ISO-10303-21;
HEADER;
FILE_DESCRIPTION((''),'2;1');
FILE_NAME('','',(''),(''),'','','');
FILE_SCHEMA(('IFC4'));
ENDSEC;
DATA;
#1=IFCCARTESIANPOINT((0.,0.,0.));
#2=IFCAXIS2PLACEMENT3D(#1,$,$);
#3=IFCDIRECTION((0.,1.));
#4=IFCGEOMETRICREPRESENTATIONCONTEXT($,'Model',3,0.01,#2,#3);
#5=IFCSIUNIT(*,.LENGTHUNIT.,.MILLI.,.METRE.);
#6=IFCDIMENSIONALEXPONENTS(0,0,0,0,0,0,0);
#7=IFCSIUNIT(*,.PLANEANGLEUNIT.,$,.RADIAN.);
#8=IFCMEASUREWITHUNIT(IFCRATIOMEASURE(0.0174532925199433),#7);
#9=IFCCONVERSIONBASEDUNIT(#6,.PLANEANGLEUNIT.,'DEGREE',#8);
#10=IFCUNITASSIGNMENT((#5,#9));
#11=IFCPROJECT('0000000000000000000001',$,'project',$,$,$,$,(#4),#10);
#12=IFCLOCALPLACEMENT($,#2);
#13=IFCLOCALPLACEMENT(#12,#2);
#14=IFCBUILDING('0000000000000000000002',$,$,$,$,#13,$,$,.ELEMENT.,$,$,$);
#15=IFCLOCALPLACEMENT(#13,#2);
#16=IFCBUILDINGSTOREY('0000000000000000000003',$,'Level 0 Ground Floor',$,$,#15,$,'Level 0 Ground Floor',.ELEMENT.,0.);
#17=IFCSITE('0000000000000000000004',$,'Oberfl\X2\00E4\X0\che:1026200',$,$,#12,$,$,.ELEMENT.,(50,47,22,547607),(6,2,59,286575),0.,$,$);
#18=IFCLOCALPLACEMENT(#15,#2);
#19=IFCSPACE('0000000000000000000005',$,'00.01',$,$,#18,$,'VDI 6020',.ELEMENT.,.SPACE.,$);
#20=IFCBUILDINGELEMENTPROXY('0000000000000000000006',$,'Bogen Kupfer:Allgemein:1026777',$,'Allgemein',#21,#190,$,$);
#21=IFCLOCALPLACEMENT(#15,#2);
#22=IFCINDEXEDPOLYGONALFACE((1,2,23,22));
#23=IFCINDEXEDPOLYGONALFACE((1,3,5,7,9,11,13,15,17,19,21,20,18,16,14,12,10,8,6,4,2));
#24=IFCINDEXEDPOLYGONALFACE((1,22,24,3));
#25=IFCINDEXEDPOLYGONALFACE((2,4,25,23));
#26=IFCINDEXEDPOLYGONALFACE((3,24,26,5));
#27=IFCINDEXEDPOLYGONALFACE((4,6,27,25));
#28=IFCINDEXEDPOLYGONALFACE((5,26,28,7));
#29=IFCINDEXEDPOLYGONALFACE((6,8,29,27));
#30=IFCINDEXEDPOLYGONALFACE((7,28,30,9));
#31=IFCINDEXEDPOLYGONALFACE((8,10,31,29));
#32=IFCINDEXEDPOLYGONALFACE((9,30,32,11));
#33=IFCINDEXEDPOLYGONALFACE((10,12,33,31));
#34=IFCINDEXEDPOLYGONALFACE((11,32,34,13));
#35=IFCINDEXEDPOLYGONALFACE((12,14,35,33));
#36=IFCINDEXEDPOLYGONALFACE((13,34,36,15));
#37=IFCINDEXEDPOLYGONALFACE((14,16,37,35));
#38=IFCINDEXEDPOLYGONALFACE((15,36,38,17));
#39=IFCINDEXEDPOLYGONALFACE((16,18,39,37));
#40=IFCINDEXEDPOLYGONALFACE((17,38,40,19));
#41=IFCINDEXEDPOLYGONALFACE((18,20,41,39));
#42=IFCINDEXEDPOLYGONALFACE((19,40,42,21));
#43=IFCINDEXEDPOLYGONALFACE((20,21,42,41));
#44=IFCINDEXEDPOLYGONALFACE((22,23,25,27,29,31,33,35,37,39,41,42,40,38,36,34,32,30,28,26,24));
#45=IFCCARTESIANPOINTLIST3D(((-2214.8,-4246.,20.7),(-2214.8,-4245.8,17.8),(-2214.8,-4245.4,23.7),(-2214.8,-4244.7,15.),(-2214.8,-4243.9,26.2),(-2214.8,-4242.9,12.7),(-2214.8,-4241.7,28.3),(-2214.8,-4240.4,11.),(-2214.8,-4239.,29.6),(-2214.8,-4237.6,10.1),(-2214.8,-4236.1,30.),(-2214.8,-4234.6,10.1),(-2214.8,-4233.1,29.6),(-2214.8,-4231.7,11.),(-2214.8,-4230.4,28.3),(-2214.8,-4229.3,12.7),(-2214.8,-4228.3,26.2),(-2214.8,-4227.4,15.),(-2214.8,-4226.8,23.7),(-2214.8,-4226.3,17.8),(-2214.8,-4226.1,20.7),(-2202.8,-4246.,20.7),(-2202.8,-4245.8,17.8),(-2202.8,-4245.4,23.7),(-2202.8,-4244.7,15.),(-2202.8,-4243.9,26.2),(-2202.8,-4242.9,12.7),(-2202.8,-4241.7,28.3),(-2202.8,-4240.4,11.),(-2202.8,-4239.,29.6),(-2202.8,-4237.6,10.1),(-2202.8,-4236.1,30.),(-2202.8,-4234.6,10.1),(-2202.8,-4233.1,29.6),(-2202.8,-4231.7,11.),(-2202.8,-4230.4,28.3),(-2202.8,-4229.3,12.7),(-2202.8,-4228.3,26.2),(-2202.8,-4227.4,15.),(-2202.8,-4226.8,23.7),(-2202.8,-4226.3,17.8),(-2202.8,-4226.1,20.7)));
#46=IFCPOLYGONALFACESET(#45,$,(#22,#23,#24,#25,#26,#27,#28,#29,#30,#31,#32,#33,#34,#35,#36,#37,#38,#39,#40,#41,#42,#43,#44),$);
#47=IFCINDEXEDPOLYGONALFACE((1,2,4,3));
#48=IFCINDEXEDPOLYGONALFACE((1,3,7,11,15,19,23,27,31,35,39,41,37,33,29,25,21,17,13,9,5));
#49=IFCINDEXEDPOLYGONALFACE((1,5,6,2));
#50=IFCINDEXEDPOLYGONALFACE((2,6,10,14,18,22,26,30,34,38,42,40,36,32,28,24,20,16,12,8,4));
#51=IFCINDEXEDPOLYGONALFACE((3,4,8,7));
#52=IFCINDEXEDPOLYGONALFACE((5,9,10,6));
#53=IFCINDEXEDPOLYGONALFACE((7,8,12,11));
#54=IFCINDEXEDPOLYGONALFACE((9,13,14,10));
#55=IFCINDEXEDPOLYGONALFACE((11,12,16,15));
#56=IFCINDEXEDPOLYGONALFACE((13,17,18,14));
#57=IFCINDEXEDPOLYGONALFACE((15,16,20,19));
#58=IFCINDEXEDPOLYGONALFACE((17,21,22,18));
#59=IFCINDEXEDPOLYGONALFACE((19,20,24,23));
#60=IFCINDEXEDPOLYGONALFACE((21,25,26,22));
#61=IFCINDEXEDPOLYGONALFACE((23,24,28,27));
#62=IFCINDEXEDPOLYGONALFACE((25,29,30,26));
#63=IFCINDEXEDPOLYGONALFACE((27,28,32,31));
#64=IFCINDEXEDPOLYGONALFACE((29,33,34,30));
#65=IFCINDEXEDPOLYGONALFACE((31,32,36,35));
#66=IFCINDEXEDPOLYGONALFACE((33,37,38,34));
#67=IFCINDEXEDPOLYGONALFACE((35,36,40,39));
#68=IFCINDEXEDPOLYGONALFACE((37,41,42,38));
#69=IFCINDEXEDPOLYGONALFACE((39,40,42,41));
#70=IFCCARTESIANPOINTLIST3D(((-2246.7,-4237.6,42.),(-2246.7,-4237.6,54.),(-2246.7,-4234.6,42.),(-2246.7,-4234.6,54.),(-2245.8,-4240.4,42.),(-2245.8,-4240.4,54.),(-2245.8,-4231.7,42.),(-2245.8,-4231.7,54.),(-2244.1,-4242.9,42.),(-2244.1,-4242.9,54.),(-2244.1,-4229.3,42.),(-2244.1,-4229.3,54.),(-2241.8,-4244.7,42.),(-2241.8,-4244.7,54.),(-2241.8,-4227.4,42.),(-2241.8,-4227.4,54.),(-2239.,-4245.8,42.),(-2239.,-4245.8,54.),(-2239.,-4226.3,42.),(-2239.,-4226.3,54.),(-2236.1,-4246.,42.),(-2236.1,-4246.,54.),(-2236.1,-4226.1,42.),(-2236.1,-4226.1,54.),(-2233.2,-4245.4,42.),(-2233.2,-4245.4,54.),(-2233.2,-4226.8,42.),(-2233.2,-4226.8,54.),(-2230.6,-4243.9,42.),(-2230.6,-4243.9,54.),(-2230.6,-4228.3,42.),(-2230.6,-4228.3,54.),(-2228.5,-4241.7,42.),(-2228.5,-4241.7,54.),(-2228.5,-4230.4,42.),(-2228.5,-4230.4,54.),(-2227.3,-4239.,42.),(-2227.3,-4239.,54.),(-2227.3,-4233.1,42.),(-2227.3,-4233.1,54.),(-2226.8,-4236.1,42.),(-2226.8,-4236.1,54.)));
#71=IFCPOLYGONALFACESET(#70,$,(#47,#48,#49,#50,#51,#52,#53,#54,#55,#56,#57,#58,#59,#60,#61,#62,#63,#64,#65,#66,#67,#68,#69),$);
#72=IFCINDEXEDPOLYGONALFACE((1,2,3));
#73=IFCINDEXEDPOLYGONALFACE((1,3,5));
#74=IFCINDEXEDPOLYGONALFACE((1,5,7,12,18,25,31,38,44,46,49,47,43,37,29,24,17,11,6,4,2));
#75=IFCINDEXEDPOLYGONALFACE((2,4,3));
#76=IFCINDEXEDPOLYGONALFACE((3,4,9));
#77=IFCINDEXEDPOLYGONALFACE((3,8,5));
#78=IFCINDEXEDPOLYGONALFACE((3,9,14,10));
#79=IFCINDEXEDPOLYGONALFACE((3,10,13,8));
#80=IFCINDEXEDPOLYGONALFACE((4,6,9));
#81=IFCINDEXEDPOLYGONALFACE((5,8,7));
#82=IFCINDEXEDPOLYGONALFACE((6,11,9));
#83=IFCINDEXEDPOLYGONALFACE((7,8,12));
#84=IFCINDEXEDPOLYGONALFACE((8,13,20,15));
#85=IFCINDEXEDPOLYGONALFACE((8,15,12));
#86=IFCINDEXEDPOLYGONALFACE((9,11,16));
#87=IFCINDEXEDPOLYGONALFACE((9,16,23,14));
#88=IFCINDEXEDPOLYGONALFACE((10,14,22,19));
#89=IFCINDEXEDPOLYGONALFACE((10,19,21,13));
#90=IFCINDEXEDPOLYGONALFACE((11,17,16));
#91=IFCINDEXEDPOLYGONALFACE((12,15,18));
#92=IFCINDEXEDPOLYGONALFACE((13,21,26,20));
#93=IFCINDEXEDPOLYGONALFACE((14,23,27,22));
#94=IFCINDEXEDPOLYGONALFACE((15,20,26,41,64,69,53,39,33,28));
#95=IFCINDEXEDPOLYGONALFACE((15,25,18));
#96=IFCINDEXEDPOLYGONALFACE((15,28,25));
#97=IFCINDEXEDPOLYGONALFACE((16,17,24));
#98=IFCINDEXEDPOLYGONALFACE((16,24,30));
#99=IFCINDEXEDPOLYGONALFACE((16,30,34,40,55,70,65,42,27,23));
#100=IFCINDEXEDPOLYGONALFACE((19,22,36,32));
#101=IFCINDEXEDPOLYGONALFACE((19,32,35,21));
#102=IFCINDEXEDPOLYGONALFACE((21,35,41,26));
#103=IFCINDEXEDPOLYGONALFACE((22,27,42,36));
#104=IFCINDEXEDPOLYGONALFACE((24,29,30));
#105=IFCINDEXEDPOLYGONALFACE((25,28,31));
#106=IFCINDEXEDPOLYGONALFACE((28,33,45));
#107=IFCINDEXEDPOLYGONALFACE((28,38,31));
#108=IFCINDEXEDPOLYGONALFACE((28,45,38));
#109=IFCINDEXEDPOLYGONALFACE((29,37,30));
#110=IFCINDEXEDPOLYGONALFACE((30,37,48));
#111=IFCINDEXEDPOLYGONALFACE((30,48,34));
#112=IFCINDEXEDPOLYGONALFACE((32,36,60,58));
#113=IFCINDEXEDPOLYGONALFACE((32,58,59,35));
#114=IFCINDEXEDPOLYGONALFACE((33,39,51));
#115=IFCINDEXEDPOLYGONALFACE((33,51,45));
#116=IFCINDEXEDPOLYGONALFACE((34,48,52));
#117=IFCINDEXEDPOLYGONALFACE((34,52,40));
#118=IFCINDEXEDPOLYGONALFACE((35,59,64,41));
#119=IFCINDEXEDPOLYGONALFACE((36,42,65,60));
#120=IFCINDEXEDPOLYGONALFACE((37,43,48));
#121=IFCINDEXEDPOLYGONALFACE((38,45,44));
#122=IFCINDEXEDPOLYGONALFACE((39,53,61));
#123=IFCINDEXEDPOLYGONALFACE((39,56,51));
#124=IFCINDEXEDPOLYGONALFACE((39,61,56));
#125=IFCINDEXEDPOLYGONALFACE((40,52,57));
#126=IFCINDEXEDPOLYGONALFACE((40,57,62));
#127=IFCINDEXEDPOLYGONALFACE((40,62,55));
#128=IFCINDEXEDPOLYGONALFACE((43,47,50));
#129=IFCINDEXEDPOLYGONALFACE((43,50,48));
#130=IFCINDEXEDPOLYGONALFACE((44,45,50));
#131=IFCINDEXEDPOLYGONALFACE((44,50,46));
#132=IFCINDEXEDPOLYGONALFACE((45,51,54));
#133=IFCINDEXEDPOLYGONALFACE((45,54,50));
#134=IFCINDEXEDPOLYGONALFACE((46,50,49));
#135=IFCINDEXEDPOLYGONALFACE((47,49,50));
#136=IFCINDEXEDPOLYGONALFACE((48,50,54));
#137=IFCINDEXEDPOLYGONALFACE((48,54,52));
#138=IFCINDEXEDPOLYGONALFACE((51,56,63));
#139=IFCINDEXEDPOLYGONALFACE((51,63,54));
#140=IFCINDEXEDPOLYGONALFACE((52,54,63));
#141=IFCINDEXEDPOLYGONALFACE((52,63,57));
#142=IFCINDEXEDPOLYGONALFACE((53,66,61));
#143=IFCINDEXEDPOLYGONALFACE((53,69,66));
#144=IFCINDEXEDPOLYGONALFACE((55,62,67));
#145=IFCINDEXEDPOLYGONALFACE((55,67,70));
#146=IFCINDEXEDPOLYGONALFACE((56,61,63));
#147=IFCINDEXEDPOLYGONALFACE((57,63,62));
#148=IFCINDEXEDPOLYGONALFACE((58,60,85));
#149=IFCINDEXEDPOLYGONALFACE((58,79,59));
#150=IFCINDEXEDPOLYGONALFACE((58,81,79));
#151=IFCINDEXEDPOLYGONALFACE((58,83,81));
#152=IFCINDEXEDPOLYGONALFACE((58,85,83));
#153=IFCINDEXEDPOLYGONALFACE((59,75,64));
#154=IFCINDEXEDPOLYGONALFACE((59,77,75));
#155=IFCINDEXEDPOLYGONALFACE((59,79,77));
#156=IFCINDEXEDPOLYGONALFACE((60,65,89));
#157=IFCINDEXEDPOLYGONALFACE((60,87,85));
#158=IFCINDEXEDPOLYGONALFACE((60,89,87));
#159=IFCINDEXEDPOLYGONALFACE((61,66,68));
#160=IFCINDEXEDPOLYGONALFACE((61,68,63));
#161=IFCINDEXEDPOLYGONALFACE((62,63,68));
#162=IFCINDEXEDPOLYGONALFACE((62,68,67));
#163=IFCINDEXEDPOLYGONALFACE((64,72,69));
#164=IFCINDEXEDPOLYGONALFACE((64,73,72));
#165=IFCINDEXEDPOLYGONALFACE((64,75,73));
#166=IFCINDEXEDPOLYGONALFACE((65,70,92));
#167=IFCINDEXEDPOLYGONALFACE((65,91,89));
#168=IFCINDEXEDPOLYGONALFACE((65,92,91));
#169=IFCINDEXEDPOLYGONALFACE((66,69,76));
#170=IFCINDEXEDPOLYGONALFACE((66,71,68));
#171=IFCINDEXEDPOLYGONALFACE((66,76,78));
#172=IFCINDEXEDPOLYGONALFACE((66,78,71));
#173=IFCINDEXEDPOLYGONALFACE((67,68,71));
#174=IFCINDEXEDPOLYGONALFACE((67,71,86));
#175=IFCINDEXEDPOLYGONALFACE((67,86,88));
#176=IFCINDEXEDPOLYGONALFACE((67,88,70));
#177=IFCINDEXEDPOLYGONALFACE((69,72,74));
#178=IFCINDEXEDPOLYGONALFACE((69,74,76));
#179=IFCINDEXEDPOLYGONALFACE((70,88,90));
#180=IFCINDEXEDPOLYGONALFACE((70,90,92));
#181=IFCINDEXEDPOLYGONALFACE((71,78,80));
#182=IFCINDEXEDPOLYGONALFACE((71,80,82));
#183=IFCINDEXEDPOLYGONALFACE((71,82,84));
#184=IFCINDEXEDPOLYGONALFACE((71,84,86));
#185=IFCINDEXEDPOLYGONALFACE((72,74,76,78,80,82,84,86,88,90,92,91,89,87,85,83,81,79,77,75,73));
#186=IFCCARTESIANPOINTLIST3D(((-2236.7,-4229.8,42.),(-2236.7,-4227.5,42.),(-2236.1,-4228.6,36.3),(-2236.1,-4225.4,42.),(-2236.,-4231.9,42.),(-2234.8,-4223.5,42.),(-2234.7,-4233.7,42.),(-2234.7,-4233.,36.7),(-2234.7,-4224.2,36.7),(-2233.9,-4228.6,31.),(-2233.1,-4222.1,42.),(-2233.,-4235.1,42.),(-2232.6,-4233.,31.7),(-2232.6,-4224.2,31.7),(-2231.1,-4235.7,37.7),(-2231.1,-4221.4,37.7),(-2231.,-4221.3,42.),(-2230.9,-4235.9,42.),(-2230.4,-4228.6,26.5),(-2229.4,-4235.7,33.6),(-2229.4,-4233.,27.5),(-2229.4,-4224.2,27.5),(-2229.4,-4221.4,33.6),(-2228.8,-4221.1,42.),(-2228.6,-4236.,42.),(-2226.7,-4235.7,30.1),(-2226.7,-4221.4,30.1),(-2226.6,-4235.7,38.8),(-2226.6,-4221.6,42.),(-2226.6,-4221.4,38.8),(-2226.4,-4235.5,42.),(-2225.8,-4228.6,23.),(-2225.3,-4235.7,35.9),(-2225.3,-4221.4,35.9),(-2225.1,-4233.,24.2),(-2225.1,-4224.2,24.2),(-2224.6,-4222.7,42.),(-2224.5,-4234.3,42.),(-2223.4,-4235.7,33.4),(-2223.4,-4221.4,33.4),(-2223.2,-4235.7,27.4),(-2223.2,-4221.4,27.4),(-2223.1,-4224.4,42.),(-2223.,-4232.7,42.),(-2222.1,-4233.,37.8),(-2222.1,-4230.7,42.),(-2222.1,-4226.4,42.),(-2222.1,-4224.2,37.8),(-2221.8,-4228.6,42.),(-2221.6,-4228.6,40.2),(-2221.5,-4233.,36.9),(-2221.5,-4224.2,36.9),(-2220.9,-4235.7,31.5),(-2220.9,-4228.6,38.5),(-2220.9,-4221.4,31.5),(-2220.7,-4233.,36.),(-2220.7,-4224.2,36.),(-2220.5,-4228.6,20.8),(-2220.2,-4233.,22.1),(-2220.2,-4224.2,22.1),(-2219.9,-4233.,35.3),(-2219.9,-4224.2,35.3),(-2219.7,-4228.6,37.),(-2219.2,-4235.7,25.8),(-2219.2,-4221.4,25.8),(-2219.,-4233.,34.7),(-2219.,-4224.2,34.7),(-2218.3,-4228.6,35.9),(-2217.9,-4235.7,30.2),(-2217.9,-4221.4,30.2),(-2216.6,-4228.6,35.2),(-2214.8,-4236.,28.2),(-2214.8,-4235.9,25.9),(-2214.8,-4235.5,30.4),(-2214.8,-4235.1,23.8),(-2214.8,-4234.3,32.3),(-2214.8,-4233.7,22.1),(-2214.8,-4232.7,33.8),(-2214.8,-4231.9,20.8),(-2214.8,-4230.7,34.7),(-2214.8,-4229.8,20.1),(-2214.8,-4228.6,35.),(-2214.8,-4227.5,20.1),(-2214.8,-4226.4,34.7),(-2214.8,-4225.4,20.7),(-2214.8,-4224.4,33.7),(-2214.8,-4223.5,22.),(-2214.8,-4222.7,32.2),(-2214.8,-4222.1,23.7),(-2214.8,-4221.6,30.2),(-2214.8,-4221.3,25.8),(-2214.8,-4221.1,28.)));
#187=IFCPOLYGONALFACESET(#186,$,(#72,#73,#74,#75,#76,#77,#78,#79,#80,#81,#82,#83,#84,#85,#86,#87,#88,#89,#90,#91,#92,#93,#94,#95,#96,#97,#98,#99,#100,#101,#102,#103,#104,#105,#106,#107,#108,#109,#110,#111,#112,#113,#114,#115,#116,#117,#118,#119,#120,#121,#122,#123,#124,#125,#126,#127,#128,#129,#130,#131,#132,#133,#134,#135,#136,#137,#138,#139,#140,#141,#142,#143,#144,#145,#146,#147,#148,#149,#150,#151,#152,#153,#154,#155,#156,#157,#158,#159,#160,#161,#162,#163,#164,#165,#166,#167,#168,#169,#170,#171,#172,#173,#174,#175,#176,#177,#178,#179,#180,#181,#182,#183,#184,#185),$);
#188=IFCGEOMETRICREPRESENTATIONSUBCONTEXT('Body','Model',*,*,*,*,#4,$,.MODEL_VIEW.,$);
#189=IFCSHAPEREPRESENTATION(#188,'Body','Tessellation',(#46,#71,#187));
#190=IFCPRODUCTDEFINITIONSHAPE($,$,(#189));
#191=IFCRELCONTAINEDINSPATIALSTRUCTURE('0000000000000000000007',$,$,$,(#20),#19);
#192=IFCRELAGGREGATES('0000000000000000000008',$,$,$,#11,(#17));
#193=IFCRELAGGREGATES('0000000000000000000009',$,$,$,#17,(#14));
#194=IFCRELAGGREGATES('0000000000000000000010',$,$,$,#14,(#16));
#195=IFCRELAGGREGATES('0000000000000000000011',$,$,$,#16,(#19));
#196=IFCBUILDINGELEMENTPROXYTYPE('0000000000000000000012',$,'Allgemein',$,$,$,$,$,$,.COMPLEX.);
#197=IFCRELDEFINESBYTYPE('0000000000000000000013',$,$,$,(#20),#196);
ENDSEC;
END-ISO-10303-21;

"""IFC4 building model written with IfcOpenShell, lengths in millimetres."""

from ifc_helpers import new_model, entity, si_unit, converted_unit, direction, frame, frame_2d, origin, place, context, subcontext, project, spatial, circle, extrude, source, transform, mapped, type_object, type_shapes, element, save


model = new_model("IFC4")

# Units and contexts
model_context = context("Model", 3, precision=0.01, world=origin(), true_north=direction((0.0, 1.0)))
body_context = subcontext(model_context, "Body", "Model", "MODEL_VIEW")
ifc_project = project(units=[si_unit("LENGTHUNIT", "METRE", prefix="MILLI"), converted_unit("PLANEANGLEUNIT", "DEGREE", entity("IfcRatioMeasure", 0.0174532925199433), si_unit("PLANEANGLEUNIT", "RADIAN"), dimensions=[0, 0, 0, 0, 0, 0, 0])], contexts=[model_context])

# Site, building, storey
site_placement = place(None, origin())
site = spatial("IfcSite", under=ifc_project, at=site_placement, Name="Oberfläche:1026200", CompositionType="ELEMENT", RefLatitude=(50, 47, 22, 547607), RefLongitude=(6, 2, 59, 286575), RefElevation=0.0)
building_placement = place(site_placement, origin())
building = spatial("IfcBuilding", under=site, at=building_placement, CompositionType="ELEMENT")
storey_placement = place(building_placement, origin())
storey = spatial("IfcBuildingStorey", under=building, at=storey_placement, Name="Level 0 Ground Floor", LongName="Level 0 Ground Floor", CompositionType="ELEMENT", Elevation=0.0)

# Shared definitions
space_placement = place(storey_placement, origin())
space = spatial("IfcSpace", under=storey, at=space_placement, Name="00.01", LongName="VDI 6020", CompositionType="ELEMENT", PredefinedType="SPACE")

# Building element proxy
building_element_proxy_type = type_object("IfcBuildingElementProxyType", Name="Allgemein", PredefinedType="COMPLEX")
ifc_direction = entity("IfcDirection", [0.0, 0.0, -1.0])
trimmed_curve = entity("IfcTrimmedCurve", entity("IfcCircle", entity("IfcAxis2Placement2D", entity("IfcCartesianPoint", [-14.5, 0.0]), entity("IfcDirection", [0.0, 1.0])), 14.5), [entity("IfcParameterValue", 270.0)], [entity("IfcParameterValue", 0.0)], True, "PARAMETER")
shared_shape_1 = source(origin(), body_context, "Body", "SolidModel", [
    extrude(circle(Radius=10.0, at=frame_2d((0.0, 0.0), x_axis=(1.0, 0.0))), frame((0.0, 22.0, 0.0), z_axis=(0.0, 1.0, 0.0), x_axis=(-1.0, 0.0, 0.0)), (0.0, 0.0, 1.0), 12.0),
    extrude(circle(Radius=10.0, at=frame_2d((0.0, 0.0), x_axis=(1.0, 0.0))), frame((-34.0, 0.0, 0.0), z_axis=(1.0, 0.0, 0.0), x_axis=(0.0, 1.0, 0.0)), (0.0, 0.0, 1.0), 12.0),
    entity("IfcSurfaceCurveSweptAreaSolid", entity("IfcCircleProfileDef", "AREA", None, entity("IfcAxis2Placement2D", entity("IfcCartesianPoint", [0.0, 7.5]), entity("IfcDirection", [1.0, 0.0])), 7.5), entity("IfcAxis2Placement3D", entity("IfcCartesianPoint", [-7.5, 22.0, 0.0]), ifc_direction, entity("IfcDirection", [1.0, 0.0, 0.0])), trimmed_curve, 0.0, 90.0, entity("IfcSurfaceOfLinearExtrusion", entity("IfcArbitraryOpenProfileDef", "CURVE", None, trimmed_curve), entity("IfcAxis2Placement3D", entity("IfcCartesianPoint", [0.0, 0.0, -304.8])), ifc_direction, 1.0)),
])
type_shapes(building_element_proxy_type, [shared_shape_1])
for number, where, z_axis, x_axis, name in (
    (1, (-2236.8, -4236.1, 20.0), (0.0, -1.0, 0.0), (0.0, 0.0, -1.0), "Bogen Kupfer:Allgemein:1026777"),
):
    element("IfcBuildingElementProxy", number, at=place(space_placement, frame(where, z_axis=z_axis, x_axis=x_axis)), inside=space, type_object=building_element_proxy_type, Name=name, ObjectType="Allgemein", context=body_context, shape_type="MappedRepresentation", body=[
        mapped(shared_shape_1, transform((0.0, 0.0, 0.0), scale=1.0)),
    ])

save(model, "model.ifc")
